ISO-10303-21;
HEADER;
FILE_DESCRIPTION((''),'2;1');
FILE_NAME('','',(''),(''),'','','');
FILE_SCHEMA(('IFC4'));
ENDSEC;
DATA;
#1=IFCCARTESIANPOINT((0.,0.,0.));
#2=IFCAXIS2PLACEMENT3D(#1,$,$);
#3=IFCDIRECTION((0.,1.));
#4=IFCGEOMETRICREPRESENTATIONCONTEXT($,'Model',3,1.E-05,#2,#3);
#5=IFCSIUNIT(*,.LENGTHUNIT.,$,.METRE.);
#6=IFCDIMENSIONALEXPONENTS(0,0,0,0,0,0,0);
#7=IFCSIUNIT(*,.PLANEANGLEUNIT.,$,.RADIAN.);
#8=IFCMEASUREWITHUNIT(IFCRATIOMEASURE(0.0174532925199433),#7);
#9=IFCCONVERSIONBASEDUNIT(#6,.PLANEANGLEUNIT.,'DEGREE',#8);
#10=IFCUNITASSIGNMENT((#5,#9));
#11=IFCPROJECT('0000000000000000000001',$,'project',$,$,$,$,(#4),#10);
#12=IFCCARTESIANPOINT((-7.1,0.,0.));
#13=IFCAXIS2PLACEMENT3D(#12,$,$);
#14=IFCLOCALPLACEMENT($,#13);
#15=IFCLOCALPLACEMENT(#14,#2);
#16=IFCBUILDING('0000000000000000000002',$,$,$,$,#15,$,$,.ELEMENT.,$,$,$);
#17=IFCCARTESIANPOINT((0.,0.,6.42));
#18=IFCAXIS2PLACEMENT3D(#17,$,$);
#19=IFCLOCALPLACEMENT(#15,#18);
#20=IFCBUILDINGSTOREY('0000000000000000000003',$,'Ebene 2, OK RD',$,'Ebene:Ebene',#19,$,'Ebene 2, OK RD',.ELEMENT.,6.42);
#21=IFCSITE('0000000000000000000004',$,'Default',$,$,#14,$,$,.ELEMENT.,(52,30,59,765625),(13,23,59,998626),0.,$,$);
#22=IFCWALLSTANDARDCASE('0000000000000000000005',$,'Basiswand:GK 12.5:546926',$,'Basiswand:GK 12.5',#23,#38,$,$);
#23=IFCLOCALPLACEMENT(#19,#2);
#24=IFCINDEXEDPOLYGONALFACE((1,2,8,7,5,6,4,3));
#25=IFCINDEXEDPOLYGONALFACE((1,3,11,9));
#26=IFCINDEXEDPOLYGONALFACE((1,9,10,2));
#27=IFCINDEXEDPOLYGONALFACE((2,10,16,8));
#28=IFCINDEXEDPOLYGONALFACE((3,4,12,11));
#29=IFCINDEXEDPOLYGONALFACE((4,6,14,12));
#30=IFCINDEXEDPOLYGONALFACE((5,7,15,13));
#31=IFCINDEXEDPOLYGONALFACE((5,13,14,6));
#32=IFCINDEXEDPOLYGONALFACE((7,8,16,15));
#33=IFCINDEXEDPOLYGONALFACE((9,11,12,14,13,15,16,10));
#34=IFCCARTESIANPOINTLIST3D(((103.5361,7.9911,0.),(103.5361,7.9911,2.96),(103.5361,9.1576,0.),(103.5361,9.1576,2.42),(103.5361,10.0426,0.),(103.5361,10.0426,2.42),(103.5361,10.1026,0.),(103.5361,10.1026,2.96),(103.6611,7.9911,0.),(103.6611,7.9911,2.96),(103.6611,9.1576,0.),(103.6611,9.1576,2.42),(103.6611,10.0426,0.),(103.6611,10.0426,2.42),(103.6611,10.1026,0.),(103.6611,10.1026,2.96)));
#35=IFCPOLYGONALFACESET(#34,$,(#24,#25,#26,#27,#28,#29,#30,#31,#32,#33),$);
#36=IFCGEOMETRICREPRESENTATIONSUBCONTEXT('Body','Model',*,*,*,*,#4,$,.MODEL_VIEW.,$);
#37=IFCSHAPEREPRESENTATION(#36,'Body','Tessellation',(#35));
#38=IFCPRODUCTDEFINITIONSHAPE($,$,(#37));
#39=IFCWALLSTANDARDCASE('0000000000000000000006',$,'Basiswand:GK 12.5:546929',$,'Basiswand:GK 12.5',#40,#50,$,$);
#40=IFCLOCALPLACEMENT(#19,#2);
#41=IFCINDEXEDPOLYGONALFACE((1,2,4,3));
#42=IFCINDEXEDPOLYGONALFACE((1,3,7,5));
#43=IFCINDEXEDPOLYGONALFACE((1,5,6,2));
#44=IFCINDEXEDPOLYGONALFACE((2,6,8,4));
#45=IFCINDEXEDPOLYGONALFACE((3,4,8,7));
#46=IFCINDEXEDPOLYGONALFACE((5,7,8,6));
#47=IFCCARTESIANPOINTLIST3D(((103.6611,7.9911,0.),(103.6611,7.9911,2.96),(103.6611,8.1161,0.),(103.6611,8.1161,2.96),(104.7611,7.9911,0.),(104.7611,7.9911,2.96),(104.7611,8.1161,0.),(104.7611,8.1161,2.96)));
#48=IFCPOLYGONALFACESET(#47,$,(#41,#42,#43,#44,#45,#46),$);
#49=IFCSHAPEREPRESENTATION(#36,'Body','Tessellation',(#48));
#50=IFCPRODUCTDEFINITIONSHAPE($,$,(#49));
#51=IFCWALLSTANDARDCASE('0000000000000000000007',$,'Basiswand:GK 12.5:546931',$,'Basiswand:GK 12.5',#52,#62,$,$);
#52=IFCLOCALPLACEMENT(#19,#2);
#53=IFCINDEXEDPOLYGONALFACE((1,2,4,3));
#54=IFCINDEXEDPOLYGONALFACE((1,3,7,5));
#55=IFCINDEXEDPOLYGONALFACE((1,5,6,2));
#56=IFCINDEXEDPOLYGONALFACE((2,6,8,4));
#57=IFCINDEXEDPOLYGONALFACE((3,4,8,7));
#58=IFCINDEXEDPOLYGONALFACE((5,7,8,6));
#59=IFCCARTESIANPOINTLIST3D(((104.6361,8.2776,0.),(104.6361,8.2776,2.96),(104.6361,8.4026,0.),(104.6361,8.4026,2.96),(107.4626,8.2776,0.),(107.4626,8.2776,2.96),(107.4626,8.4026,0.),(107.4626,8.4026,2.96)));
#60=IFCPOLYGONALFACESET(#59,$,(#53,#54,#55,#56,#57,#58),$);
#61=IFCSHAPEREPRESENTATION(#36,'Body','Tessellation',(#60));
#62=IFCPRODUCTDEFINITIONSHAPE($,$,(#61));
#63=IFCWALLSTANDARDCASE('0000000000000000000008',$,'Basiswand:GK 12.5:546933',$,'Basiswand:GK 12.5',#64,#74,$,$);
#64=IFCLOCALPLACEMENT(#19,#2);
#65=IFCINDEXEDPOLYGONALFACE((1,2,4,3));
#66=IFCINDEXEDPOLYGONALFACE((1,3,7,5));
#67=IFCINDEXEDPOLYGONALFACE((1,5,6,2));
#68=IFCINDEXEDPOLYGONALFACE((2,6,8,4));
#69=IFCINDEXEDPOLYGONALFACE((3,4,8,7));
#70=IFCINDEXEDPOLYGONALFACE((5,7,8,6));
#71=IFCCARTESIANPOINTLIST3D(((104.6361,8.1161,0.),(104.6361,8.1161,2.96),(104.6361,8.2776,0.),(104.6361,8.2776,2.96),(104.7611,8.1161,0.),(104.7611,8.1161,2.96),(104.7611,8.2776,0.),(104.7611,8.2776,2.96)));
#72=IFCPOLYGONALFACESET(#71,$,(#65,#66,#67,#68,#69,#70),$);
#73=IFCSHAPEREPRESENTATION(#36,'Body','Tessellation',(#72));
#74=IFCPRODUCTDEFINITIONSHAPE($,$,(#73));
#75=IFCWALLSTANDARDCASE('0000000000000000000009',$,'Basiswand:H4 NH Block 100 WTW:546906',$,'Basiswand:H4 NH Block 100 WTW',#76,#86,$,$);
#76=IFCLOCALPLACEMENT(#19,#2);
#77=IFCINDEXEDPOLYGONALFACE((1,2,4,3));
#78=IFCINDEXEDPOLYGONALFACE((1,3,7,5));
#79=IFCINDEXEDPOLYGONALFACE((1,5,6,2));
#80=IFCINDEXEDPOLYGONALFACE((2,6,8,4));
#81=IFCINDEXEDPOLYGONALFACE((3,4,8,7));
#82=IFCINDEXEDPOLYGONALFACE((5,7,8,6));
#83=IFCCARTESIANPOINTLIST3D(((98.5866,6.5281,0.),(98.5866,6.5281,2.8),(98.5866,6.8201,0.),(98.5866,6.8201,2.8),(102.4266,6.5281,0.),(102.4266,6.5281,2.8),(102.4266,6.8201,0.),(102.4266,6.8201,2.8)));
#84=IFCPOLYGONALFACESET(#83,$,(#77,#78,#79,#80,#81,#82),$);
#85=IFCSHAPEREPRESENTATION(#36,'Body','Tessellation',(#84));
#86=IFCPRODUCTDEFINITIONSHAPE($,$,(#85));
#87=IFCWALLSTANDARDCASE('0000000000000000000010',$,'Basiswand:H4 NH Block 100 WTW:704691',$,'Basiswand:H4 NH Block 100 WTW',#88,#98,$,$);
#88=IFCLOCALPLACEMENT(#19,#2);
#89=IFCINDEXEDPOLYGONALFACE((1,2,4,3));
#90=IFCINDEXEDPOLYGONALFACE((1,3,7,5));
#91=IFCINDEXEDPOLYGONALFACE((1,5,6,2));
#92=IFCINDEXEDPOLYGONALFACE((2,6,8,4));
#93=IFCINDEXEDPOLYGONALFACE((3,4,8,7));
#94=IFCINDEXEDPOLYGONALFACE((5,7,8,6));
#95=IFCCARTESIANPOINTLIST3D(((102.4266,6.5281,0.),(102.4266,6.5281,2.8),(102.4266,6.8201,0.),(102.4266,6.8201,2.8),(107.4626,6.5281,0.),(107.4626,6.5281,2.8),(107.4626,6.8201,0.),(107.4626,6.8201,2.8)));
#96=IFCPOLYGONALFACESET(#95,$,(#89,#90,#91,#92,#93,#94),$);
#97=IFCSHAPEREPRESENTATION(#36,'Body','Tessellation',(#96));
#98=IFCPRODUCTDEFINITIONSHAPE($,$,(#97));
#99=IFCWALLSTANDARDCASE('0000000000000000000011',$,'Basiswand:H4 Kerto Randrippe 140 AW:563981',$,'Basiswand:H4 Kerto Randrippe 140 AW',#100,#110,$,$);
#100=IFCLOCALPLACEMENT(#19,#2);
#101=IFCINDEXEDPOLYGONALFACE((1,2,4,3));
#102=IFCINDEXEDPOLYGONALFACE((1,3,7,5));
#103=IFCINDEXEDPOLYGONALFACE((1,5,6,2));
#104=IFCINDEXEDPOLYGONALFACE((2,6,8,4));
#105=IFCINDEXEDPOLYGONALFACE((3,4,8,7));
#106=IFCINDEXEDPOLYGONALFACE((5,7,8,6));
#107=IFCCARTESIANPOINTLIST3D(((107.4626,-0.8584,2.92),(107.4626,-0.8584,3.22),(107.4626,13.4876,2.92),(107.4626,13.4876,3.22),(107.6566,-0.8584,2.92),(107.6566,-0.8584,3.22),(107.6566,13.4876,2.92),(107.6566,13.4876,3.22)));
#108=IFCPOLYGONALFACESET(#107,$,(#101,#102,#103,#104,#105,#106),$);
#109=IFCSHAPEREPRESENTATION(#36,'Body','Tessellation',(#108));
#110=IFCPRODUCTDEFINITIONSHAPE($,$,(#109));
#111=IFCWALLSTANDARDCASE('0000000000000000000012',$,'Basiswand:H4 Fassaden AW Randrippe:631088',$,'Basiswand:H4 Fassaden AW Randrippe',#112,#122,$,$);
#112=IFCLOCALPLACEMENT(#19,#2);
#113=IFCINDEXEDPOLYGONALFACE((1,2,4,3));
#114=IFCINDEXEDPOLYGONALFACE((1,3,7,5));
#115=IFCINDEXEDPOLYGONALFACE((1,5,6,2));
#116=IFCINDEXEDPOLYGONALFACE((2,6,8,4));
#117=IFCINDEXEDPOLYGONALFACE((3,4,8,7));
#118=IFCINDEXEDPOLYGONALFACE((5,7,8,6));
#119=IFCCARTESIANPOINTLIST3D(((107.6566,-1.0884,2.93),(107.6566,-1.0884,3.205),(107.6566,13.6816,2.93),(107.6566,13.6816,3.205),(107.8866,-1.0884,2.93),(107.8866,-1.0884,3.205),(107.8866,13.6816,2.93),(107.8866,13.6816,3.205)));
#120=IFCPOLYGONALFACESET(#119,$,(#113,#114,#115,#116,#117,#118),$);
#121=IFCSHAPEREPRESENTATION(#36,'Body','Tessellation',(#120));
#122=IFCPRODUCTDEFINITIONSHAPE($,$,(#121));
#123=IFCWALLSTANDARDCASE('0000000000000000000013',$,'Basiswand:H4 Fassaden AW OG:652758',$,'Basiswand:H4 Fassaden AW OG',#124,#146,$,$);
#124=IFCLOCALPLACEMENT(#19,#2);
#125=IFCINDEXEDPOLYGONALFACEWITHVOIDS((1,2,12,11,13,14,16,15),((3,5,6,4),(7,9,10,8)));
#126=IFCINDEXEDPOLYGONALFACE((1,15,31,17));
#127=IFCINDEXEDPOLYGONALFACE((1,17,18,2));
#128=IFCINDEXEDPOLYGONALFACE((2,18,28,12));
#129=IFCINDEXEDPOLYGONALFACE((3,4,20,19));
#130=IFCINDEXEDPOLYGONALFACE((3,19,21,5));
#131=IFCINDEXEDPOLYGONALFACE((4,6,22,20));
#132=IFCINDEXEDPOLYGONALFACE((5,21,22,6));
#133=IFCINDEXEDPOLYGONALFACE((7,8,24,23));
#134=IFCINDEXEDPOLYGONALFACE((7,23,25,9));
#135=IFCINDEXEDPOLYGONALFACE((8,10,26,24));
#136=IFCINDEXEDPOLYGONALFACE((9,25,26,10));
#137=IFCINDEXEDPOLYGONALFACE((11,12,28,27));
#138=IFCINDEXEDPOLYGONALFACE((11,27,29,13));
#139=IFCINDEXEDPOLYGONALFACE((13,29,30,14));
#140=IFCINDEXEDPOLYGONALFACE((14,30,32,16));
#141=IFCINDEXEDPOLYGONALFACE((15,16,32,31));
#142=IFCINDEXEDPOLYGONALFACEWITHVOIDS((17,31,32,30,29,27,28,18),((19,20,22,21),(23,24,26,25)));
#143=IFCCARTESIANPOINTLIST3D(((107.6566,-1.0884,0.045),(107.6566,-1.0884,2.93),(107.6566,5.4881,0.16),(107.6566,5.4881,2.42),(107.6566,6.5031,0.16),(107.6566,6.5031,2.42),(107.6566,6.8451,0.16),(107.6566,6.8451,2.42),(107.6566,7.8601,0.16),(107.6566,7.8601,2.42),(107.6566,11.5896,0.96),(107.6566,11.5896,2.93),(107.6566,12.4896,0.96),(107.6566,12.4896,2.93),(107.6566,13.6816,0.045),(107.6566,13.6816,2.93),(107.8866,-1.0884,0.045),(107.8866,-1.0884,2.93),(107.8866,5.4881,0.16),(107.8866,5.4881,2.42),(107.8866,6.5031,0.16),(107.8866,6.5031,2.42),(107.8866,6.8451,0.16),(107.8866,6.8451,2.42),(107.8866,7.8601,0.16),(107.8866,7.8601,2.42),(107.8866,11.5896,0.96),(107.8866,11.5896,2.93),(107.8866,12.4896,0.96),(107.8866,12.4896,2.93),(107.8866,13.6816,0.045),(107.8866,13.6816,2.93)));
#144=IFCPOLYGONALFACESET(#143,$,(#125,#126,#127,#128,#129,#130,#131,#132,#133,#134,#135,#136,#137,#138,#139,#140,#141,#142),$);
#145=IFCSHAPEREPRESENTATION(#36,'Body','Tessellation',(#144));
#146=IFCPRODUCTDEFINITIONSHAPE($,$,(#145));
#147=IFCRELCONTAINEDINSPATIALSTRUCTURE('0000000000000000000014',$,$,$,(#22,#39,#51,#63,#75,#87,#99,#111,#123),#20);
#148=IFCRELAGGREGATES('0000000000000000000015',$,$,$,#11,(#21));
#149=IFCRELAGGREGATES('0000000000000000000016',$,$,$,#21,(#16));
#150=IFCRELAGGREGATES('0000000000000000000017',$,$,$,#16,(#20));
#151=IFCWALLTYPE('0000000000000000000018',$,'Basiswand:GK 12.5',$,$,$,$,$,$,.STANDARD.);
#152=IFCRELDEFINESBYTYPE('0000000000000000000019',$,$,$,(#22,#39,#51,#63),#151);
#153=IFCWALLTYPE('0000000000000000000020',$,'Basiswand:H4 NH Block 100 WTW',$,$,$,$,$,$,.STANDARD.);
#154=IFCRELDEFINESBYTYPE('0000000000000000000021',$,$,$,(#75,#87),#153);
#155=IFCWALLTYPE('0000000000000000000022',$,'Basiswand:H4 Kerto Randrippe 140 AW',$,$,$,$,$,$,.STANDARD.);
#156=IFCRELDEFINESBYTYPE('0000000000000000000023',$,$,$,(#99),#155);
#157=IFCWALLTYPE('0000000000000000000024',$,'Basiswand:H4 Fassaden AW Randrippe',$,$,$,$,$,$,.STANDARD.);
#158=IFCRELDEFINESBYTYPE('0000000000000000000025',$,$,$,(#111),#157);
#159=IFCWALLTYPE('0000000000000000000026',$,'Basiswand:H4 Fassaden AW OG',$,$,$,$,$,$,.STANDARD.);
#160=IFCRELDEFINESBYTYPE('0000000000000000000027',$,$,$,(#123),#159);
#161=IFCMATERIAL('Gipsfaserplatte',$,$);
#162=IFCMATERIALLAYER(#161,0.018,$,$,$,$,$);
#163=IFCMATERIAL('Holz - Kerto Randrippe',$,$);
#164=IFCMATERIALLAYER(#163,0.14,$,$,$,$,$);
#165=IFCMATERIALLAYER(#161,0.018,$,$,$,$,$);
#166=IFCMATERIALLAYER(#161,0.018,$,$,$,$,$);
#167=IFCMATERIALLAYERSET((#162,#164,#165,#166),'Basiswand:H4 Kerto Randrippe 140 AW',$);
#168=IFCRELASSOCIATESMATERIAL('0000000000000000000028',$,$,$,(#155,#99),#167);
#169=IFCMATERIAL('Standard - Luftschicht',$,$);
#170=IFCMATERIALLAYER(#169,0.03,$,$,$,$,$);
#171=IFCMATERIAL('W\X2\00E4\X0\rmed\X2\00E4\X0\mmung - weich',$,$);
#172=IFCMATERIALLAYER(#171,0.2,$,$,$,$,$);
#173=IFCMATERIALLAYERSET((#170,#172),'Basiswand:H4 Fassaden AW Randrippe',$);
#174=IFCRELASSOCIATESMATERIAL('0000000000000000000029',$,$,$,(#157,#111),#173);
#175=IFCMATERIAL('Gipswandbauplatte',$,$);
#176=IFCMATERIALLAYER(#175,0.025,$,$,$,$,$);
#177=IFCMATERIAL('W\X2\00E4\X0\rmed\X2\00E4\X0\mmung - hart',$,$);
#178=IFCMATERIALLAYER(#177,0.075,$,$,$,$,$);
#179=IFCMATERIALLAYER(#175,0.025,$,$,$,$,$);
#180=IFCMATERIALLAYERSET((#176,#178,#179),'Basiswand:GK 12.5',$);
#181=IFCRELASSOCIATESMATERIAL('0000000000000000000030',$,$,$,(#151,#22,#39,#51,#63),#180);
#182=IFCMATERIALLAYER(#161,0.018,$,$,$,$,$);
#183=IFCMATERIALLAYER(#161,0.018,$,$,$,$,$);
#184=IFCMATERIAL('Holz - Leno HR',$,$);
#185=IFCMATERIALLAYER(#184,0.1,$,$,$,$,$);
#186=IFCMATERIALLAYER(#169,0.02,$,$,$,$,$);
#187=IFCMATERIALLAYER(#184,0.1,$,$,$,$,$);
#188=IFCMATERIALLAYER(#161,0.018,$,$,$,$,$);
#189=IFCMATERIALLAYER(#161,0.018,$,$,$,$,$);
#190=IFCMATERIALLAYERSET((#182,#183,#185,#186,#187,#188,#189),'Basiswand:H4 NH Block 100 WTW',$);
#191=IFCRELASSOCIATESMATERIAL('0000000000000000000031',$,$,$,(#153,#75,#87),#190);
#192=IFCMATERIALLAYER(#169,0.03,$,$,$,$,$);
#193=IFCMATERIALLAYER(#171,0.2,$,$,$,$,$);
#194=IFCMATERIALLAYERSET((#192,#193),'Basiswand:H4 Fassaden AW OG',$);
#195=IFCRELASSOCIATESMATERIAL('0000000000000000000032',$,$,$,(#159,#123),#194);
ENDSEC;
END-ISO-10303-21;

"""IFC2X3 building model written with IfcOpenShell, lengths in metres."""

from ifc_helpers import new_model, entity, si_unit, converted_unit, direction, frame, frame_2d, origin, place, context, subcontext, project, spatial, rectangle, extrude, material, layer, layer_set, layer_usage, type_object, element, save


model = new_model("IFC2X3")

# Units and contexts
model_context = context("Model", 3, precision=1e-05, world=origin(), true_north=direction((0.0, 1.0)))
body_context = subcontext(model_context, "Body", "Model", "MODEL_VIEW")
ifc_project = project(units=[si_unit("LENGTHUNIT", "METRE"), converted_unit("PLANEANGLEUNIT", "DEGREE", entity("IfcRatioMeasure", 0.0174532925199433), si_unit("PLANEANGLEUNIT", "RADIAN"), dimensions=[0, 0, 0, 0, 0, 0, 0])], contexts=[model_context])

# Site, building, storey
site_placement = place(None, frame((-7.1, 0.0, 0.0)))
site = spatial("IfcSite", under=ifc_project, at=site_placement, Name="Default", CompositionType="ELEMENT", RefLatitude=(52, 30, 59, 765625), RefLongitude=(13, 23, 59, 998626), RefElevation=0.0)
building_placement = place(site_placement, origin())
building = spatial("IfcBuilding", under=site, at=building_placement, CompositionType="ELEMENT")
storey_placement = place(building_placement, frame((0.0, 0.0, 6.42)))
storey = spatial("IfcBuildingStorey", under=building, at=storey_placement, Name="Ebene 2, OK RD", ObjectType="Ebene:Ebene", LongName="Ebene 2, OK RD", CompositionType="ELEMENT", Elevation=6.42)

# Shared definitions
ifc_material_1 = material(Name="Gipsfaserplatte")
ifc_layer_1 = layer(ifc_material_1, 0.018)
ifc_material_2 = material(Name="Holz - Kerto Randrippe")
ifc_layer_2 = layer(ifc_material_2, 0.14)
ifc_layer_3 = layer(ifc_material_1, 0.018)
ifc_layer_4 = layer(ifc_material_1, 0.018)
ifc_layer_set_1 = layer_set([ifc_layer_1, ifc_layer_2, ifc_layer_3, ifc_layer_4], Name="Basiswand:H4 Kerto Randrippe 140 AW")
wall_type_1 = type_object("IfcWallType", Name="Basiswand:H4 Kerto Randrippe 140 AW", PredefinedType="STANDARD", material=ifc_layer_set_1)

# Shared definitions
ifc_material_3 = material(Name="Standard - Luftschicht")
ifc_layer_5 = layer(ifc_material_3, 0.03)
ifc_material_4 = material(Name="Wärmedämmung - weich")
ifc_layer_6 = layer(ifc_material_4, 0.2)
ifc_layer_set_2 = layer_set([ifc_layer_5, ifc_layer_6], Name="Basiswand:H4 Fassaden AW Randrippe")
wall_type_2 = type_object("IfcWallType", Name="Basiswand:H4 Fassaden AW Randrippe", PredefinedType="STANDARD", material=ifc_layer_set_2)

# Shared definitions
ifc_material_5 = material(Name="Holz - Leno HR")

# Shared definitions
ifc_material_6 = material(Name="Gipswandbauplatte")
ifc_layer_7 = layer(ifc_material_6, 0.025)
ifc_material_7 = material(Name="Wärmedämmung - hart")
ifc_layer_8 = layer(ifc_material_7, 0.075)
ifc_layer_9 = layer(ifc_material_6, 0.025)
ifc_layer_set_3 = layer_set([ifc_layer_7, ifc_layer_8, ifc_layer_9], Name="Basiswand:GK 12.5")
wall_type_3 = type_object("IfcWallType", Name="Basiswand:GK 12.5", PredefinedType="STANDARD", material=ifc_layer_set_3)

# Wall, opening
ifc_layer_usage_1 = layer_usage(ifc_layer_set_3, "AXIS2", "NEGATIVE", 0.0625)
wall_1_placement = place(storey_placement, frame((103.5986, 10.1026, 0.0), z_axis=(0.0, 0.0, 1.0), x_axis=(0.0, -1.0, 0.0)))
wall_1 = element("IfcWallStandardCase", 1, at=wall_1_placement, inside=storey, type_object=wall_type_3, material=ifc_layer_usage_1, Name="Basiswand:GK 12.5:546926", ObjectType="Basiswand:GK 12.5", context=body_context, shape_type="SweptSolid", body=[
    extrude(rectangle(XDim=2.1115, YDim=0.125, at=frame_2d((1.0557, 0.0), x_axis=(-1.0, 0.0))), origin(), (0.0, 0.0, 1.0), 2.96),
])
opening_1_placement = place(wall_1_placement, frame((0.06, -0.0625, 0.0)))
element("IfcOpeningElement", 2, at=opening_1_placement, cuts=wall_1, ObjectType="Opening", context=body_context, shape_type="SweptSolid", body=[
    extrude(rectangle(XDim=2.42, YDim=0.885, at=frame_2d((1.21, 0.4425), x_axis=(1.0, 0.0))), frame((0.0, 0.0, 0.0), z_axis=(0.0, 1.0, 0.0), x_axis=(0.0, 0.0, 1.0)), (0.0, 0.0, 1.0), 0.125),
])

# Walls
ifc_layer_usage_2 = layer_usage(ifc_layer_set_3, "AXIS2", "NEGATIVE", 0.0625)
wall_2_placement = place(storey_placement, frame((103.6611, 8.0536, 0.0)))
element("IfcWallStandardCase", 3, at=wall_2_placement, inside=storey, type_object=wall_type_3, material=ifc_layer_usage_2, Name="Basiswand:GK 12.5:546929", ObjectType="Basiswand:GK 12.5", context=body_context, shape_type="SweptSolid", body=[
    extrude(rectangle(XDim=1.1, YDim=0.125, at=frame_2d((0.55, 0.0), x_axis=(-1.0, 0.0))), origin(), (0.0, 0.0, 1.0), 2.96),
])
ifc_layer_usage_3 = layer_usage(ifc_layer_set_3, "AXIS2", "NEGATIVE", 0.0625)
wall_3_placement = place(storey_placement, frame((104.6361, 8.3401, 0.0)))
element("IfcWallStandardCase", 4, at=wall_3_placement, inside=storey, type_object=wall_type_3, material=ifc_layer_usage_3, Name="Basiswand:GK 12.5:546931", ObjectType="Basiswand:GK 12.5", context=body_context, shape_type="SweptSolid", body=[
    extrude(rectangle(XDim=2.8265, YDim=0.125, at=frame_2d((1.4133, 0.0), x_axis=(-1.0, 0.0))), origin(), (0.0, 0.0, 1.0), 2.96),
])
ifc_layer_usage_4 = layer_usage(ifc_layer_set_3, "AXIS2", "NEGATIVE", 0.0625)
wall_4_placement = place(storey_placement, frame((104.6986, 8.1161, 0.0), z_axis=(0.0, 0.0, 1.0), x_axis=(0.0, 1.0, 0.0)))
element("IfcWallStandardCase", 5, at=wall_4_placement, inside=storey, type_object=wall_type_3, material=ifc_layer_usage_4, Name="Basiswand:GK 12.5:546933", ObjectType="Basiswand:GK 12.5", context=body_context, shape_type="SweptSolid", body=[
    extrude(rectangle(XDim=0.1615, YDim=0.125, at=frame_2d((0.0807, 0.0), x_axis=(-1.0, 0.0))), origin(), (0.0, 0.0, 1.0), 2.96),
])
ifc_layer_10 = layer(ifc_material_1, 0.018)
ifc_layer_11 = layer(ifc_material_1, 0.018)
ifc_layer_12 = layer(ifc_material_5, 0.1)
ifc_layer_13 = layer(ifc_material_3, 0.02)
ifc_layer_14 = layer(ifc_material_5, 0.1)
ifc_layer_15 = layer(ifc_material_1, 0.018)
ifc_layer_16 = layer(ifc_material_1, 0.018)
ifc_layer_set_4 = layer_set([ifc_layer_10, ifc_layer_11, ifc_layer_12, ifc_layer_13, ifc_layer_14, ifc_layer_15, ifc_layer_16], Name="Basiswand:H4 NH Block 100 WTW")
ifc_layer_usage_5 = layer_usage(ifc_layer_set_4, "AXIS2", "NEGATIVE", 0.146)
wall_type_4 = type_object("IfcWallType", Name="Basiswand:H4 NH Block 100 WTW", PredefinedType="STANDARD", material=ifc_layer_set_4)
wall_5_placement = place(storey_placement, frame((98.5866, 6.6741, 0.0)))
element("IfcWallStandardCase", 6, at=wall_5_placement, inside=storey, type_object=wall_type_4, material=ifc_layer_usage_5, Name="Basiswand:H4 NH Block 100 WTW:546906", ObjectType="Basiswand:H4 NH Block 100 WTW", context=body_context, shape_type="SweptSolid", body=[
    extrude(rectangle(XDim=3.84, YDim=0.292, at=frame_2d((1.92, 0.0), x_axis=(-1.0, 0.0))), origin(), (0.0, 0.0, 1.0), 2.8),
])
ifc_layer_usage_6 = layer_usage(ifc_layer_set_4, "AXIS2", "NEGATIVE", 0.146)
wall_6_placement = place(storey_placement, frame((102.4266, 6.6741, 0.0)))
element("IfcWallStandardCase", 7, at=wall_6_placement, inside=storey, type_object=wall_type_4, material=ifc_layer_usage_6, Name="Basiswand:H4 NH Block 100 WTW:704691", ObjectType="Basiswand:H4 NH Block 100 WTW", context=body_context, shape_type="SweptSolid", body=[
    extrude(rectangle(XDim=5.036, YDim=0.292, at=frame_2d((2.518, 0.0), x_axis=(-1.0, 0.0))), origin(), (0.0, 0.0, 1.0), 2.8),
])
ifc_layer_usage_7 = layer_usage(ifc_layer_set_1, "AXIS2", "NEGATIVE", 0.097)
wall_7_placement = place(storey_placement, frame((107.5596, 13.4876, 2.92), z_axis=(0.0, 0.0, 1.0), x_axis=(0.0, -1.0, 0.0)))
element("IfcWallStandardCase", 8, at=wall_7_placement, inside=storey, type_object=wall_type_1, material=ifc_layer_usage_7, Name="Basiswand:H4 Kerto Randrippe 140 AW:563981", ObjectType="Basiswand:H4 Kerto Randrippe 140 AW", context=body_context, shape_type="SweptSolid", body=[
    extrude(rectangle(XDim=14.346, YDim=0.194, at=frame_2d((7.173, 0.0), x_axis=(-1.0, 0.0))), origin(), (0.0, 0.0, 1.0), 0.3),
])
ifc_layer_usage_8 = layer_usage(ifc_layer_set_2, "AXIS2", "NEGATIVE", 0.115)
wall_8_placement = place(storey_placement, frame((107.7716, 13.6816, 2.93), z_axis=(0.0, 0.0, 1.0), x_axis=(0.0, -1.0, 0.0)))
element("IfcWallStandardCase", 9, at=wall_8_placement, inside=storey, type_object=wall_type_2, material=ifc_layer_usage_8, Name="Basiswand:H4 Fassaden AW Randrippe:631088", ObjectType="Basiswand:H4 Fassaden AW Randrippe", context=body_context, shape_type="SweptSolid", body=[
    extrude(rectangle(XDim=14.77, YDim=0.23, at=frame_2d((7.385, 0.0), x_axis=(-1.0, 0.0))), origin(), (0.0, 0.0, 1.0), 0.275),
])

# Wall, openings
ifc_layer_17 = layer(ifc_material_3, 0.03)
ifc_layer_18 = layer(ifc_material_4, 0.2)
ifc_layer_set_5 = layer_set([ifc_layer_17, ifc_layer_18], Name="Basiswand:H4 Fassaden AW OG")
ifc_layer_usage_9 = layer_usage(ifc_layer_set_5, "AXIS2", "NEGATIVE", 0.115)
wall_type_5 = type_object("IfcWallType", Name="Basiswand:H4 Fassaden AW OG", PredefinedType="STANDARD", material=ifc_layer_set_5)
wall_9_placement = place(storey_placement, frame((107.7716, 13.6816, 0.045), z_axis=(0.0, 0.0, 1.0), x_axis=(0.0, -1.0, 0.0)))
wall_9 = element("IfcWallStandardCase", 10, at=wall_9_placement, inside=storey, type_object=wall_type_5, material=ifc_layer_usage_9, Name="Basiswand:H4 Fassaden AW OG:652758", ObjectType="Basiswand:H4 Fassaden AW OG", context=body_context, shape_type="SweptSolid", body=[
    extrude(rectangle(XDim=14.77, YDim=0.23, at=frame_2d((7.385, 0.0), x_axis=(-1.0, 0.0))), origin(), (0.0, 0.0, 1.0), 2.885),
])
opening_2_placement = place(wall_9_placement, frame((2.092, 0.115, 0.915)))
element("IfcOpeningElement", 11, at=opening_2_placement, cuts=wall_9, ObjectType="Opening", context=body_context, shape_type="SweptSolid", body=[
    extrude(rectangle(XDim=1.97, YDim=0.9, at=frame_2d((0.985, 0.45), x_axis=(1.0, 0.0))), frame((0.0, 0.0, 0.0), z_axis=(0.0, -1.0, 0.0), x_axis=(0.0, 0.0, 1.0)), (0.0, 0.0, 1.0), 0.23),
])
opening_3_placement = place(wall_9_placement, frame((8.1935, 0.115, 0.115)))
element("IfcOpeningElement", 12, at=opening_3_placement, cuts=wall_9, ObjectType="Opening", context=body_context, shape_type="SweptSolid", body=[
    extrude(rectangle(XDim=2.26, YDim=1.015, at=frame_2d((1.13, 0.5075), x_axis=(1.0, 0.0))), frame((0.0, 0.0, 0.0), z_axis=(0.0, -1.0, 0.0), x_axis=(0.0, 0.0, 1.0)), (0.0, 0.0, 1.0), 0.23),
])
opening_4_placement = place(wall_9_placement, frame((6.8365, 0.115, 0.115)))
element("IfcOpeningElement", 13, at=opening_4_placement, cuts=wall_9, ObjectType="Opening", context=body_context, shape_type="SweptSolid", body=[
    extrude(rectangle(XDim=2.26, YDim=1.015, at=frame_2d((1.13, 0.5075), x_axis=(1.0, 0.0))), frame((0.0, 0.0, 0.0), z_axis=(0.0, -1.0, 0.0), x_axis=(0.0, 0.0, 1.0)), (0.0, 0.0, 1.0), 0.23),
])

save(model, "model.ifc")
